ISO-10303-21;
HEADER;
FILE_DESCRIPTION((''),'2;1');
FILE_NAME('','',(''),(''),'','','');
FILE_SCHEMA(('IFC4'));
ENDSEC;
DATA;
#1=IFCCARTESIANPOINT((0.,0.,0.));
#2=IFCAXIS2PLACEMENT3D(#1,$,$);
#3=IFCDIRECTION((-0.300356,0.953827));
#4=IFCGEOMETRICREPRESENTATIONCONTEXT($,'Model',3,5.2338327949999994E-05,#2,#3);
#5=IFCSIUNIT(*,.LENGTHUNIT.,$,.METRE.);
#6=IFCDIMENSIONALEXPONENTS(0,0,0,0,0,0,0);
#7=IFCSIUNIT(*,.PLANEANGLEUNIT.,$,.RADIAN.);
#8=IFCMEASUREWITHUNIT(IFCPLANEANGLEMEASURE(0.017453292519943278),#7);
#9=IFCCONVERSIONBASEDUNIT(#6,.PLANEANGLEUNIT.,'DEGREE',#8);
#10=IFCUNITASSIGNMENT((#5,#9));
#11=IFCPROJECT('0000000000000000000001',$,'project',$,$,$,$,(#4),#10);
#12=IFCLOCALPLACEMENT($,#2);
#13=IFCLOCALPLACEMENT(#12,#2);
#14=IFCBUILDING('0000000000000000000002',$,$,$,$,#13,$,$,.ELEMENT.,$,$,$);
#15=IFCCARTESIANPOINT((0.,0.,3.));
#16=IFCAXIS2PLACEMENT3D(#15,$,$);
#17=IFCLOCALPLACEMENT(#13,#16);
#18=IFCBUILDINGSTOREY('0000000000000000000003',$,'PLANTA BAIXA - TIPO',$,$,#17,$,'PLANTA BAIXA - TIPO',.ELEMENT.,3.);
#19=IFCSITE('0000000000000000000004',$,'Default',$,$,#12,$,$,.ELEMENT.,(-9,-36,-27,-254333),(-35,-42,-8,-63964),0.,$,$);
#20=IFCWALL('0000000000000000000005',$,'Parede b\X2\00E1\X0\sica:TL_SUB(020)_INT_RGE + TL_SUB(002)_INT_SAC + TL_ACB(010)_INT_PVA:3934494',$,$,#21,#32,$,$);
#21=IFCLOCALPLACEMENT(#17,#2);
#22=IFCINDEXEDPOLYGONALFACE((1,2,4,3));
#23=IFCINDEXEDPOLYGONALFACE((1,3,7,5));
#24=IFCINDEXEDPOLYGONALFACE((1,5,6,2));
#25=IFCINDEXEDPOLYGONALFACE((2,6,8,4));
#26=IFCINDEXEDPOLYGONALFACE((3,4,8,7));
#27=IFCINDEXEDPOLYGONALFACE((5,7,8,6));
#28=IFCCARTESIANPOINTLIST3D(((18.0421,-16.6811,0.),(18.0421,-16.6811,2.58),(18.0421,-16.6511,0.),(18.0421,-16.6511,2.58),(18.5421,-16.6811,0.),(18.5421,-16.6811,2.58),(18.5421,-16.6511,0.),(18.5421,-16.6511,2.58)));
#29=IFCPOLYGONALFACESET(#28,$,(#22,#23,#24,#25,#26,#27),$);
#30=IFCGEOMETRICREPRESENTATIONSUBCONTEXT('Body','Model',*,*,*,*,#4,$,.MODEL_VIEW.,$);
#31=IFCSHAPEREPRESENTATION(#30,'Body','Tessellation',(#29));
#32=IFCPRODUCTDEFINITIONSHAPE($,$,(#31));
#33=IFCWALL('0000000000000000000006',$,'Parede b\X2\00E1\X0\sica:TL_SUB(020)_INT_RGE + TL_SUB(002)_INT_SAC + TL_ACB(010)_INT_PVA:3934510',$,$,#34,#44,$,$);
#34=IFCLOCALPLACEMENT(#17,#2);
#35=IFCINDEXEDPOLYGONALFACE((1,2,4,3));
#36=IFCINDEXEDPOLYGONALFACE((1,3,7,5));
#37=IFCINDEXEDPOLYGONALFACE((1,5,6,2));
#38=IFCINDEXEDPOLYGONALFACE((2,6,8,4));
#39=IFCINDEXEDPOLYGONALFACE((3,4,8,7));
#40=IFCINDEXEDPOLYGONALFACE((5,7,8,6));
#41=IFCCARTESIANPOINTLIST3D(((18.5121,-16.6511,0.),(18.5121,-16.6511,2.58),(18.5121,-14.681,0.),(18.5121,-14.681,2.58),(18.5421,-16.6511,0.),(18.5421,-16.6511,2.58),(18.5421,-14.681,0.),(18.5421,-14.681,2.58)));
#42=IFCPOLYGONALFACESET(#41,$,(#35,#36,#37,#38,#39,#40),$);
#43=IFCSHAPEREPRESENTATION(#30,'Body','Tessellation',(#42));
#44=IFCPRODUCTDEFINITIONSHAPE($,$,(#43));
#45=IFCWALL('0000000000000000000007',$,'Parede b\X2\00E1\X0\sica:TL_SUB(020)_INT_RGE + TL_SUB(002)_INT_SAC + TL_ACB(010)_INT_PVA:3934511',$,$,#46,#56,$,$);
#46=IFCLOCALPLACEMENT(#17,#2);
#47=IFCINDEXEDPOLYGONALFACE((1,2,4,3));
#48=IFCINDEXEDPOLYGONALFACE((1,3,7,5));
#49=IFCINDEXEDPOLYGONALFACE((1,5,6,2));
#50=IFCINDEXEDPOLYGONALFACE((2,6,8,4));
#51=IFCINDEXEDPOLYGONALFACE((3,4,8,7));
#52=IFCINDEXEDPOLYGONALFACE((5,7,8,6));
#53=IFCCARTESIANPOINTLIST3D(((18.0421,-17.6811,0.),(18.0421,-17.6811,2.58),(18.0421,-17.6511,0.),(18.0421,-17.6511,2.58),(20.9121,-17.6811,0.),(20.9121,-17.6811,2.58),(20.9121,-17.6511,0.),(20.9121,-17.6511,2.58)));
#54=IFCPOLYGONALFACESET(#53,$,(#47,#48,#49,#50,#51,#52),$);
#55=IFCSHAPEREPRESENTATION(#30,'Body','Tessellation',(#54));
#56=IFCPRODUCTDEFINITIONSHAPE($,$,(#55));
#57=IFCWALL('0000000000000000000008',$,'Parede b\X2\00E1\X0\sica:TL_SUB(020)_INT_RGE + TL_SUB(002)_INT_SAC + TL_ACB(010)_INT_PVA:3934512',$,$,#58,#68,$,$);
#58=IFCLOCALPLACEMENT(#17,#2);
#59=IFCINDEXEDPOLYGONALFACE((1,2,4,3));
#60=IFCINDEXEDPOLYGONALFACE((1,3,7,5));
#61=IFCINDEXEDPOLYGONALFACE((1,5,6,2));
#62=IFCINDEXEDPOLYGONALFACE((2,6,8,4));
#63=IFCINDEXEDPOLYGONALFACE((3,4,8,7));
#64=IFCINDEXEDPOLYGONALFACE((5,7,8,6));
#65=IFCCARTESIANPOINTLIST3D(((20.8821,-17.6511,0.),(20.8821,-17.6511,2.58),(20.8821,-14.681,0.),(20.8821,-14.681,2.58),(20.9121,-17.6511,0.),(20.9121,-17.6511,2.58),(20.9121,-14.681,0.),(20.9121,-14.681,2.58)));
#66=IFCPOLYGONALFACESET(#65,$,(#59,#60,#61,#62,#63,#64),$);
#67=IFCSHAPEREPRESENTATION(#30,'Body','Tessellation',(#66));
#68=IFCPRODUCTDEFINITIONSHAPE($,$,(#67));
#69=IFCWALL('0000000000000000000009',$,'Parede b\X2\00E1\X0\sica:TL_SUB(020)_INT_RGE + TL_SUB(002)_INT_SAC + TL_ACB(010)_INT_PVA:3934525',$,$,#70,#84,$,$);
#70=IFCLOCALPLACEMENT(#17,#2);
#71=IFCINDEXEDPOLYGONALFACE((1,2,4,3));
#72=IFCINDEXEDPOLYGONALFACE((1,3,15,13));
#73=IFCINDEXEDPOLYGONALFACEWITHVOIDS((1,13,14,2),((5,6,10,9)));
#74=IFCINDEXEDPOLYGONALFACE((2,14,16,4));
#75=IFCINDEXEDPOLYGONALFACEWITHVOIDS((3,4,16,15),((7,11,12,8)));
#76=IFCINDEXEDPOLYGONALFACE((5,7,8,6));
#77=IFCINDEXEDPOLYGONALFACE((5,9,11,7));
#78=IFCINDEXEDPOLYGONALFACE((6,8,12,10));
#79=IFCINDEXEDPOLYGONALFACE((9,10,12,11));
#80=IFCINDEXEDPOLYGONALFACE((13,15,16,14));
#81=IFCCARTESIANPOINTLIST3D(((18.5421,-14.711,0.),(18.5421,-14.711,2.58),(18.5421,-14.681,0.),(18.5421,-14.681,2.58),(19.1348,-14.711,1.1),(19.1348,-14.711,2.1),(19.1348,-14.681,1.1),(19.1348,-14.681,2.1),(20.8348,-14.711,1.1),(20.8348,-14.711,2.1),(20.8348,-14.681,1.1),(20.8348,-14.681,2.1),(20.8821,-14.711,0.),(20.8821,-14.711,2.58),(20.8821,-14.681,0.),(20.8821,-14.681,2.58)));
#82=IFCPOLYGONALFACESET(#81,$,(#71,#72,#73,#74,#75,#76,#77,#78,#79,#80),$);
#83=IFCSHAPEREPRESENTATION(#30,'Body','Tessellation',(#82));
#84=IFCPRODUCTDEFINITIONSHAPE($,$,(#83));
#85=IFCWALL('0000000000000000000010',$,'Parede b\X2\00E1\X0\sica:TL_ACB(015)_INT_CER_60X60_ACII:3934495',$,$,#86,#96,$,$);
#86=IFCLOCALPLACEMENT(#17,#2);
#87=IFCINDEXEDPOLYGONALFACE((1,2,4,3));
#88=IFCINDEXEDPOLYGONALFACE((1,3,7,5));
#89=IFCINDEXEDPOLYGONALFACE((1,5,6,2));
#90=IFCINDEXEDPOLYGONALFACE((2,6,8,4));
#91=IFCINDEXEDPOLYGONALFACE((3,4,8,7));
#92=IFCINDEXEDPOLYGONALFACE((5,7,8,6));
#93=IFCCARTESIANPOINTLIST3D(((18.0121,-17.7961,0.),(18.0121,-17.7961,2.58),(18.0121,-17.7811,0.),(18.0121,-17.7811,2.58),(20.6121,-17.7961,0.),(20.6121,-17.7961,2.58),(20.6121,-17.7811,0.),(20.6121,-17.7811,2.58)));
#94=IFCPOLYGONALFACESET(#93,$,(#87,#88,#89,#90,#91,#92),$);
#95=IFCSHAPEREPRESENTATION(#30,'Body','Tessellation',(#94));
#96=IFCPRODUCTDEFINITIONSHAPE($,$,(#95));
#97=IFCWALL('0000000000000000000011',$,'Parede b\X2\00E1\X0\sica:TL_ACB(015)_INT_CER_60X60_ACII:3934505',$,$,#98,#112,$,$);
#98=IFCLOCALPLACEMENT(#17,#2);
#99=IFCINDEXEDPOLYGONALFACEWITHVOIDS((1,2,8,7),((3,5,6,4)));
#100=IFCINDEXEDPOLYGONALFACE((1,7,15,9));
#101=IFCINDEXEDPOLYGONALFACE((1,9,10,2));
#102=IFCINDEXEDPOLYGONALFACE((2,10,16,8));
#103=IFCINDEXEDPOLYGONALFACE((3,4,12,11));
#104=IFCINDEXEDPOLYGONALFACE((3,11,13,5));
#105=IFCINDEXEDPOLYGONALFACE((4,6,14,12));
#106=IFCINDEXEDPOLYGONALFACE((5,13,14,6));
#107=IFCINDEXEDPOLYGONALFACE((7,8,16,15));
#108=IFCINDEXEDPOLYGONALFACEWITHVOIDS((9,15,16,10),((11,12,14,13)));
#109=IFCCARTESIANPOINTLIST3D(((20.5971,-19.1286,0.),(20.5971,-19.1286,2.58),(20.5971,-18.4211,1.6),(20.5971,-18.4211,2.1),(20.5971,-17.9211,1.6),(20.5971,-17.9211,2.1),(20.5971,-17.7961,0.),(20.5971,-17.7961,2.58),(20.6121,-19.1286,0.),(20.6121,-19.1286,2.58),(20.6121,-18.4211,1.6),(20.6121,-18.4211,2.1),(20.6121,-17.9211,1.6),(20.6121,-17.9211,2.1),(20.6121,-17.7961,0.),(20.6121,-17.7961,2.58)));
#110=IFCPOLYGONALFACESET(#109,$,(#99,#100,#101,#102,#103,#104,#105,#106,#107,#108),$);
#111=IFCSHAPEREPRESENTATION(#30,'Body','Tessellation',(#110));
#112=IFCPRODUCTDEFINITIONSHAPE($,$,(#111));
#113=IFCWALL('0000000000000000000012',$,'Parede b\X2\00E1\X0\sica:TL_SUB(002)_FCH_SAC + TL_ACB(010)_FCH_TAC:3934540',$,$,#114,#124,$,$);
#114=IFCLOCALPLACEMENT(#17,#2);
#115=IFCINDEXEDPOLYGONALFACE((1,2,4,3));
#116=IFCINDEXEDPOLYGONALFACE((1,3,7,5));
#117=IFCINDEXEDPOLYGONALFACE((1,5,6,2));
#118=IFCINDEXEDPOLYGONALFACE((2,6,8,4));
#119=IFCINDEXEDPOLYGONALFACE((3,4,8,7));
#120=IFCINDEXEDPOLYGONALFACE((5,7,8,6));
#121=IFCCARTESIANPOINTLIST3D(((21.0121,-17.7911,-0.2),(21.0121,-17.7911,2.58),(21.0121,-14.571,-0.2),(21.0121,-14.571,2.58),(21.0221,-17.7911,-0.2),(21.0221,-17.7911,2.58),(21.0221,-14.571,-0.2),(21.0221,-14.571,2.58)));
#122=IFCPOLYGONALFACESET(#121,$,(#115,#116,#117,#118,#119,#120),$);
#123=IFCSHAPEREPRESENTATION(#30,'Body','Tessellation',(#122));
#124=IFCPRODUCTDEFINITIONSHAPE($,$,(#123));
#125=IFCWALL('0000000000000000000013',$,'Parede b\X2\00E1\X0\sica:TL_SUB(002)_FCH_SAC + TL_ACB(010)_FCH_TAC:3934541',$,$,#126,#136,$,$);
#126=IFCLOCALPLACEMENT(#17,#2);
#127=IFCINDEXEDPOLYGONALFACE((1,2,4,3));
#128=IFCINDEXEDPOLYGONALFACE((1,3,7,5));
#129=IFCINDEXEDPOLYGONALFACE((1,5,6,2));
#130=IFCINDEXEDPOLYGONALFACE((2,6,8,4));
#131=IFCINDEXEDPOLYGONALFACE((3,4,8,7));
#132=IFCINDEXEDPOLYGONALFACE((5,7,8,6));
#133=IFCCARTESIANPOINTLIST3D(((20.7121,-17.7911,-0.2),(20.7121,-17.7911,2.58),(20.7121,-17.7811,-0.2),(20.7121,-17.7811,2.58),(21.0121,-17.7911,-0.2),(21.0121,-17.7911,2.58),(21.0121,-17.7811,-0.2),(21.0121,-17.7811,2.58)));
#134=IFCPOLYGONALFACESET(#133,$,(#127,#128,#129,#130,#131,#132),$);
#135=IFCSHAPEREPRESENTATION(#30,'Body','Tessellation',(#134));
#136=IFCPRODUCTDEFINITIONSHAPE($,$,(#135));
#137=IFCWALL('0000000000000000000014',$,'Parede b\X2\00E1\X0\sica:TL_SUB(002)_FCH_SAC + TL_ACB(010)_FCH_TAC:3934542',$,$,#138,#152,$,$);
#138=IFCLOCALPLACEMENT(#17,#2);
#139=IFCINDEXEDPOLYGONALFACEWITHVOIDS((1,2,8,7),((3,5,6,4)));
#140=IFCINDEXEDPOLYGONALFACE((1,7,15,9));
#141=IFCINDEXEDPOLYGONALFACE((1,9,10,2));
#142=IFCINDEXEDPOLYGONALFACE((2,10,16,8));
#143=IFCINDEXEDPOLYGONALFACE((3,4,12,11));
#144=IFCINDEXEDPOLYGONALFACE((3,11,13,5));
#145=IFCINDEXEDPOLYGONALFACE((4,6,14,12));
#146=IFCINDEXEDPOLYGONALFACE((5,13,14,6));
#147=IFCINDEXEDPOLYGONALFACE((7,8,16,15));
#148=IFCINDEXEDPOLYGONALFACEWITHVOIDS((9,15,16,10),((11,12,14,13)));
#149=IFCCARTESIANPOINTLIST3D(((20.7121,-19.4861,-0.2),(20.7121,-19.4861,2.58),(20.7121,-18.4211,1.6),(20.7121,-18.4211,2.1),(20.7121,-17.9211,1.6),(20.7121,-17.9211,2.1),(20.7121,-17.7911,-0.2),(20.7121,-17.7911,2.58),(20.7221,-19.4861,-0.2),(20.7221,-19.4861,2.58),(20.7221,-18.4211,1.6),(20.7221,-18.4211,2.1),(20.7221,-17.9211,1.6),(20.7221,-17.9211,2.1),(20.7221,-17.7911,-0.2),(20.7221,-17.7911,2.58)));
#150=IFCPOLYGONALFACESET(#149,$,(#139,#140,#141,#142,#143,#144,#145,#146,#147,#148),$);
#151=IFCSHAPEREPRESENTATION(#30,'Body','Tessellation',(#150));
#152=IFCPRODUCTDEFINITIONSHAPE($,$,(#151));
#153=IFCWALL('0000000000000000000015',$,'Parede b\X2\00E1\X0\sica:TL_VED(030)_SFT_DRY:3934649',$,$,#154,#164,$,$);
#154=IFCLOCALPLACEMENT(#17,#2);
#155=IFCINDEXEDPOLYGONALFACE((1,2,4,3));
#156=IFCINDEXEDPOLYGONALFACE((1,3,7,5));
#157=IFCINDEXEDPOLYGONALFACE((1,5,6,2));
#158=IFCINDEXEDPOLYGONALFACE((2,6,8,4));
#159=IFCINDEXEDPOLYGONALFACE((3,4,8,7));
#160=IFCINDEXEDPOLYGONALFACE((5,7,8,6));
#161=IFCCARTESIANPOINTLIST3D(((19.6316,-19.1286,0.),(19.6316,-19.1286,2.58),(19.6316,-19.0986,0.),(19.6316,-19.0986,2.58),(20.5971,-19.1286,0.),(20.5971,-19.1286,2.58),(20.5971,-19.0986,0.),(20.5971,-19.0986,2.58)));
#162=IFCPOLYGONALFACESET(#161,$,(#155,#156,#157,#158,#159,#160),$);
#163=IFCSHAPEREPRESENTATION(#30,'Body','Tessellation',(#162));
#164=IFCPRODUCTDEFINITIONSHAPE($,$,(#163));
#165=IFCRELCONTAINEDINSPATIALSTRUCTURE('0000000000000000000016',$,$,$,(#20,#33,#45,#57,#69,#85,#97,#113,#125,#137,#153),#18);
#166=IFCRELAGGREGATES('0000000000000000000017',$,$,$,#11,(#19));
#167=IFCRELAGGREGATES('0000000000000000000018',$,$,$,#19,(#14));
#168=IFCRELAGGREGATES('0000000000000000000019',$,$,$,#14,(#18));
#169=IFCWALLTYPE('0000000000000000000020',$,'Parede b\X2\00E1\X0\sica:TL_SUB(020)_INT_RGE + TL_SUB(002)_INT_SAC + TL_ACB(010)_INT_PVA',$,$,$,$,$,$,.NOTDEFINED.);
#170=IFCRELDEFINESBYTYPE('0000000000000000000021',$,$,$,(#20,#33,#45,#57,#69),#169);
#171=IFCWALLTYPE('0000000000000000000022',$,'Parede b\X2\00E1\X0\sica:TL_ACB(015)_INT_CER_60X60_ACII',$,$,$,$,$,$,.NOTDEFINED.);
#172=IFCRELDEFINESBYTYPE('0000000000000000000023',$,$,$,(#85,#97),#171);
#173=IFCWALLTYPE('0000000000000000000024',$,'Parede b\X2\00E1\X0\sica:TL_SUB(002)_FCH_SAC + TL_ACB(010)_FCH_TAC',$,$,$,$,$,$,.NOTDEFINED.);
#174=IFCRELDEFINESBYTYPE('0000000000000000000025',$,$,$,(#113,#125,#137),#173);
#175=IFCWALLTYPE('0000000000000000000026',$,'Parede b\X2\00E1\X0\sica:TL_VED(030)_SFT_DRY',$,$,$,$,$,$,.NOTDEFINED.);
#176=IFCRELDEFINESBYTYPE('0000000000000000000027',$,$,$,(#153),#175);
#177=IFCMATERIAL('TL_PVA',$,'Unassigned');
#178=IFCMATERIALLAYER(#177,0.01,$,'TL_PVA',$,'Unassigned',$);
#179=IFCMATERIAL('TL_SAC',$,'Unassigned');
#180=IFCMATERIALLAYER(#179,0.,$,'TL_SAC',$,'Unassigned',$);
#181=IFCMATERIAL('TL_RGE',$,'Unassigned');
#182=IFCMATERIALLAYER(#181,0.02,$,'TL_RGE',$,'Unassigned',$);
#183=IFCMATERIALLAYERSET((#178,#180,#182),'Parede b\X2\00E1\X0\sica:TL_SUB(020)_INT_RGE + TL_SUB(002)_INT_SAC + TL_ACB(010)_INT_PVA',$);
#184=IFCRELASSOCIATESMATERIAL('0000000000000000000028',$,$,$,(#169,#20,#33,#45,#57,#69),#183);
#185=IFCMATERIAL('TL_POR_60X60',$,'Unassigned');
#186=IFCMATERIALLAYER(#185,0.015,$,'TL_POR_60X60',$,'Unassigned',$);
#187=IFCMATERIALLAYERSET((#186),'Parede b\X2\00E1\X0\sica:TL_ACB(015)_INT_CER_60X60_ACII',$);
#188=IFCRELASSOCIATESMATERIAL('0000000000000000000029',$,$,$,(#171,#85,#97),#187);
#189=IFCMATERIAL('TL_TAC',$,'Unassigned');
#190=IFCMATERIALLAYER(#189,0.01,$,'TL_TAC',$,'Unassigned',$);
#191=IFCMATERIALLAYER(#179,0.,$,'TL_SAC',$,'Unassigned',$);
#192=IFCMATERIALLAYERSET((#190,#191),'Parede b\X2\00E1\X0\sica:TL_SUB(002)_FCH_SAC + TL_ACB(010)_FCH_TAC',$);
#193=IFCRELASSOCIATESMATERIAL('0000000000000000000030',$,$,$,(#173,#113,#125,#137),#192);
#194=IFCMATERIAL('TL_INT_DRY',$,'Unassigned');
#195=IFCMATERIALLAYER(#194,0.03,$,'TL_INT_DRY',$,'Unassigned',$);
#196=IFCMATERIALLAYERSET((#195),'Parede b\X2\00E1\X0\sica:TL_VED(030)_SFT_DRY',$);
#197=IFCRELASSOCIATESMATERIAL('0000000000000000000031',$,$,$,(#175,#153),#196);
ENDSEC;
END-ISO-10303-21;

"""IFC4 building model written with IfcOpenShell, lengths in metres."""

from ifc_helpers import new_model, entity, si_unit, converted_unit, direction, frame, frame_2d, origin, place, context, subcontext, project, spatial, rectangle, extrude, material, layer, layer_set, layer_usage, type_object, element, save


model = new_model("IFC4")

# Units and contexts
model_context = context("Model", 3, precision=5.2338327949999994e-05, world=origin(), true_north=direction((-0.300356, 0.953827)))
body_context = subcontext(model_context, "Body", "Model", "MODEL_VIEW")
ifc_project = project(units=[si_unit("LENGTHUNIT", "METRE"), converted_unit("PLANEANGLEUNIT", "DEGREE", entity("IfcPlaneAngleMeasure", 0.017453292519943278), si_unit("PLANEANGLEUNIT", "RADIAN"), dimensions=[0, 0, 0, 0, 0, 0, 0])], contexts=[model_context])

# Site, building, storey
site_placement = place(None, origin())
site = spatial("IfcSite", under=ifc_project, at=site_placement, Name="Default", CompositionType="ELEMENT", RefLatitude=(-9, -36, -27, -254333), RefLongitude=(-35, -42, -8, -63964), RefElevation=0.0)
building_placement = place(site_placement, origin())
building = spatial("IfcBuilding", under=site, at=building_placement, CompositionType="ELEMENT")
storey_placement = place(building_placement, frame((0.0, 0.0, 3.0)))
storey = spatial("IfcBuildingStorey", under=building, at=storey_placement, Name="PLANTA BAIXA - TIPO", LongName="PLANTA BAIXA - TIPO", CompositionType="ELEMENT", Elevation=3.0)

# Walls
ifc_material_1 = material(Name="TL_PVA", Category="Unassigned")
ifc_layer_1 = layer(ifc_material_1, 0.01, Name="TL_PVA", Category="Unassigned")
ifc_material_2 = material(Name="TL_SAC", Category="Unassigned")
ifc_layer_2 = layer(ifc_material_2, 0.0, Name="TL_SAC", Category="Unassigned")
ifc_material_3 = material(Name="TL_RGE", Category="Unassigned")
ifc_layer_3 = layer(ifc_material_3, 0.02, Name="TL_RGE", Category="Unassigned")
ifc_layer_set_1 = layer_set([ifc_layer_1, ifc_layer_2, ifc_layer_3], Name="Parede básica:TL_SUB(020)_INT_RGE + TL_SUB(002)_INT_SAC + TL_ACB(010)_INT_PVA")
ifc_layer_usage_1 = layer_usage(ifc_layer_set_1, "AXIS2", "NEGATIVE", 0.015)
wall_type_1 = type_object("IfcWallType", Name="Parede básica:TL_SUB(020)_INT_RGE + TL_SUB(002)_INT_SAC + TL_ACB(010)_INT_PVA", PredefinedType="NOTDEFINED", material=ifc_layer_set_1)
wall_1_placement = place(storey_placement, frame((18.5421, -16.6661, 0.0), z_axis=(0.0, 0.0, 1.0), x_axis=(-1.0, 0.0, 0.0)))
element("IfcWall", 1, at=wall_1_placement, inside=storey, type_object=wall_type_1, material=ifc_layer_usage_1, Name="Parede básica:TL_SUB(020)_INT_RGE + TL_SUB(002)_INT_SAC + TL_ACB(010)_INT_PVA:3934494", context=body_context, shape_type="SweptSolid", body=[
    extrude(rectangle(XDim=0.5, YDim=0.03, at=frame_2d((0.25, 0.0), x_axis=(-1.0, 0.0))), origin(), (0.0, 0.0, 1.0), 2.58),
])
ifc_layer_usage_2 = layer_usage(ifc_layer_set_1, "AXIS2", "POSITIVE", -0.015)
wall_2_placement = place(storey_placement, frame((18.5271, -16.6511, 0.0), z_axis=(0.0, 0.0, 1.0), x_axis=(0.0, 1.0, 0.0)))
element("IfcWall", 2, at=wall_2_placement, inside=storey, type_object=wall_type_1, material=ifc_layer_usage_2, Name="Parede básica:TL_SUB(020)_INT_RGE + TL_SUB(002)_INT_SAC + TL_ACB(010)_INT_PVA:3934510", context=body_context, shape_type="SweptSolid", body=[
    extrude(rectangle(XDim=1.9701, YDim=0.03, at=frame_2d((0.9851, 0.0), x_axis=(-1.0, 0.0))), origin(), (0.0, 0.0, 1.0), 2.58),
])
ifc_layer_usage_3 = layer_usage(ifc_layer_set_1, "AXIS2", "POSITIVE", -0.015)
wall_3_placement = place(storey_placement, frame((20.9121, -17.6661, 0.0), z_axis=(0.0, 0.0, 1.0), x_axis=(-1.0, 0.0, 0.0)))
element("IfcWall", 3, at=wall_3_placement, inside=storey, type_object=wall_type_1, material=ifc_layer_usage_3, Name="Parede básica:TL_SUB(020)_INT_RGE + TL_SUB(002)_INT_SAC + TL_ACB(010)_INT_PVA:3934511", context=body_context, shape_type="SweptSolid", body=[
    extrude(rectangle(XDim=2.87, YDim=0.03, at=frame_2d((1.435, 0.0), x_axis=(-1.0, 0.0))), origin(), (0.0, 0.0, 1.0), 2.58),
])
ifc_layer_usage_4 = layer_usage(ifc_layer_set_1, "AXIS2", "POSITIVE", -0.015)
wall_4_placement = place(storey_placement, frame((20.8971, -14.681, 0.0), z_axis=(0.0, 0.0, 1.0), x_axis=(0.0, -1.0, 0.0)))
element("IfcWall", 4, at=wall_4_placement, inside=storey, type_object=wall_type_1, material=ifc_layer_usage_4, Name="Parede básica:TL_SUB(020)_INT_RGE + TL_SUB(002)_INT_SAC + TL_ACB(010)_INT_PVA:3934512", context=body_context, shape_type="SweptSolid", body=[
    extrude(rectangle(XDim=2.9701, YDim=0.03, at=frame_2d((1.4851, 0.0), x_axis=(-1.0, 0.0))), origin(), (0.0, 0.0, 1.0), 2.58),
])

# Wall, opening
ifc_layer_usage_5 = layer_usage(ifc_layer_set_1, "AXIS2", "POSITIVE", -0.015)
wall_5_placement = place(storey_placement, frame((18.5421, -14.696, 0.0)))
wall_5 = element("IfcWall", 5, at=wall_5_placement, inside=storey, type_object=wall_type_1, material=ifc_layer_usage_5, Name="Parede básica:TL_SUB(020)_INT_RGE + TL_SUB(002)_INT_SAC + TL_ACB(010)_INT_PVA:3934525", context=body_context, shape_type="SweptSolid", body=[
    extrude(rectangle(XDim=2.34, YDim=0.03, at=frame_2d((1.17, 0.0), x_axis=(-1.0, 0.0))), origin(), (0.0, 0.0, 1.0), 2.58),
])
opening_1_placement = place(wall_5_placement, frame((-18.5421, 14.696, 1.1)))
element("IfcOpeningElement", 6, at=opening_1_placement, cuts=wall_5, PredefinedType="OPENING", context=body_context, shape_type="SweptSolid", body=[
    extrude(rectangle(XDim=1.0, YDim=1.7, at=frame_2d((0.0, 0.0), x_axis=(0.0, 1.0))), frame((19.9848, -16.205, 0.5), z_axis=(0.0, 1.0, 0.0), x_axis=(1.0, 0.0, 0.0)), (0.0, 0.0, 1.0), 3.048),
])

# Wall
ifc_material_4 = material(Name="TL_POR_60X60", Category="Unassigned")
ifc_layer_4 = layer(ifc_material_4, 0.015, Name="TL_POR_60X60", Category="Unassigned")
ifc_layer_set_2 = layer_set([ifc_layer_4], Name="Parede básica:TL_ACB(015)_INT_CER_60X60_ACII")
ifc_layer_usage_6 = layer_usage(ifc_layer_set_2, "AXIS2", "NEGATIVE", 0.0075)
wall_type_2 = type_object("IfcWallType", Name="Parede básica:TL_ACB(015)_INT_CER_60X60_ACII", PredefinedType="NOTDEFINED", material=ifc_layer_set_2)
wall_6_placement = place(storey_placement, frame((20.6121, -17.7886, 0.0), z_axis=(0.0, 0.0, 1.0), x_axis=(-1.0, 0.0, 0.0)))
element("IfcWall", 7, at=wall_6_placement, inside=storey, type_object=wall_type_2, material=ifc_layer_usage_6, Name="Parede básica:TL_ACB(015)_INT_CER_60X60_ACII:3934495", context=body_context, shape_type="SweptSolid", body=[
    extrude(rectangle(XDim=2.6, YDim=0.015, at=frame_2d((1.3, 0.0), x_axis=(-1.0, 0.0))), origin(), (0.0, 0.0, 1.0), 2.58),
])

# Wall, opening
ifc_layer_usage_7 = layer_usage(ifc_layer_set_2, "AXIS2", "POSITIVE", -0.0075)
wall_7_placement = place(storey_placement, frame((20.6046, -17.7961, 0.0), z_axis=(0.0, 0.0, 1.0), x_axis=(0.0, -1.0, 0.0)))
wall_7 = element("IfcWall", 8, at=wall_7_placement, inside=storey, type_object=wall_type_2, material=ifc_layer_usage_7, Name="Parede básica:TL_ACB(015)_INT_CER_60X60_ACII:3934505", context=body_context, shape_type="SweptSolid", body=[
    extrude(rectangle(XDim=1.3325, YDim=0.015, at=frame_2d((0.6662, 0.0), x_axis=(-1.0, 0.0))), origin(), (0.0, 0.0, 1.0), 2.58),
])
opening_2_placement = place(wall_7_placement, frame((-17.7961, -20.6046, 1.6)))
element("IfcOpeningElement", 9, at=opening_2_placement, cuts=wall_7, PredefinedType="OPENING", context=body_context, shape_type="SweptSolid", body=[
    extrude(rectangle(XDim=0.5, YDim=0.5, at=frame_2d((0.0, 0.0), x_axis=(1.0, 0.0))), frame((18.1711, 19.1881, 0.25), z_axis=(0.0, 1.0, 0.0), x_axis=(0.0, 0.0, 1.0)), (0.0, 0.0, 1.0), 3.048),
])

# Walls
ifc_material_5 = material(Name="TL_TAC", Category="Unassigned")
ifc_layer_5 = layer(ifc_material_5, 0.01, Name="TL_TAC", Category="Unassigned")
ifc_layer_6 = layer(ifc_material_2, 0.0, Name="TL_SAC", Category="Unassigned")
ifc_layer_set_3 = layer_set([ifc_layer_5, ifc_layer_6], Name="Parede básica:TL_SUB(002)_FCH_SAC + TL_ACB(010)_FCH_TAC")
ifc_layer_usage_8 = layer_usage(ifc_layer_set_3, "AXIS2", "POSITIVE", -0.005)
wall_type_3 = type_object("IfcWallType", Name="Parede básica:TL_SUB(002)_FCH_SAC + TL_ACB(010)_FCH_TAC", PredefinedType="NOTDEFINED", material=ifc_layer_set_3)
wall_8_placement = place(storey_placement, frame((21.0171, -14.571, -0.2), z_axis=(0.0, 0.0, 1.0), x_axis=(0.0, -1.0, 0.0)))
element("IfcWall", 10, at=wall_8_placement, inside=storey, type_object=wall_type_3, material=ifc_layer_usage_8, Name="Parede básica:TL_SUB(002)_FCH_SAC + TL_ACB(010)_FCH_TAC:3934540", context=body_context, shape_type="SweptSolid", body=[
    extrude(rectangle(XDim=3.2201, YDim=0.01, at=frame_2d((1.6101, 0.0), x_axis=(-1.0, 0.0))), origin(), (0.0, 0.0, 1.0), 2.78),
])
ifc_layer_usage_9 = layer_usage(ifc_layer_set_3, "AXIS2", "POSITIVE", -0.005)
wall_9_placement = place(storey_placement, frame((21.0121, -17.7861, -0.2), z_axis=(0.0, 0.0, 1.0), x_axis=(-1.0, 0.0, 0.0)))
element("IfcWall", 11, at=wall_9_placement, inside=storey, type_object=wall_type_3, material=ifc_layer_usage_9, Name="Parede básica:TL_SUB(002)_FCH_SAC + TL_ACB(010)_FCH_TAC:3934541", context=body_context, shape_type="SweptSolid", body=[
    extrude(rectangle(XDim=0.3, YDim=0.01, at=frame_2d((0.15, 0.0), x_axis=(-1.0, 0.0))), origin(), (0.0, 0.0, 1.0), 2.78),
])

# Wall, opening
ifc_layer_usage_10 = layer_usage(ifc_layer_set_3, "AXIS2", "POSITIVE", -0.005)
wall_10_placement = place(storey_placement, frame((20.7171, -17.7911, -0.2), z_axis=(0.0, 0.0, 1.0), x_axis=(0.0, -1.0, 0.0)))
wall_10 = element("IfcWall", 12, at=wall_10_placement, inside=storey, type_object=wall_type_3, material=ifc_layer_usage_10, Name="Parede básica:TL_SUB(002)_FCH_SAC + TL_ACB(010)_FCH_TAC:3934542", context=body_context, shape_type="SweptSolid", body=[
    extrude(rectangle(XDim=1.695, YDim=0.01, at=frame_2d((0.8475, 0.0), x_axis=(-1.0, 0.0))), origin(), (0.0, 0.0, 1.0), 2.78),
])
opening_3_placement = place(wall_10_placement, frame((-17.7911, -20.7171, 1.8)))
element("IfcOpeningElement", 13, at=opening_3_placement, cuts=wall_10, PredefinedType="OPENING", context=body_context, shape_type="SweptSolid", body=[
    extrude(rectangle(XDim=0.5, YDim=0.5, at=frame_2d((0.0, 0.0), x_axis=(1.0, 0.0))), frame((18.1711, 19.1881, 0.25), z_axis=(0.0, 1.0, 0.0), x_axis=(0.0, 0.0, 1.0)), (0.0, 0.0, 1.0), 3.048),
])

# Wall
ifc_material_6 = material(Name="TL_INT_DRY", Category="Unassigned")
ifc_layer_7 = layer(ifc_material_6, 0.03, Name="TL_INT_DRY", Category="Unassigned")
ifc_layer_set_4 = layer_set([ifc_layer_7], Name="Parede básica:TL_VED(030)_SFT_DRY")
ifc_layer_usage_11 = layer_usage(ifc_layer_set_4, "AXIS2", "POSITIVE", -0.015)
wall_type_4 = type_object("IfcWallType", Name="Parede básica:TL_VED(030)_SFT_DRY", PredefinedType="NOTDEFINED", material=ifc_layer_set_4)
wall_11_placement = place(storey_placement, frame((20.5971, -19.1136, 0.0), z_axis=(0.0, 0.0, 1.0), x_axis=(-1.0, 0.0, 0.0)))
element("IfcWall", 14, at=wall_11_placement, inside=storey, type_object=wall_type_4, material=ifc_layer_usage_11, Name="Parede básica:TL_VED(030)_SFT_DRY:3934649", context=body_context, shape_type="SweptSolid", body=[
    extrude(rectangle(XDim=0.9655, YDim=0.03, at=frame_2d((0.4828, 0.0), x_axis=(-1.0, 0.0))), origin(), (0.0, 0.0, 1.0), 2.58),
])

save(model, "model.ifc")
